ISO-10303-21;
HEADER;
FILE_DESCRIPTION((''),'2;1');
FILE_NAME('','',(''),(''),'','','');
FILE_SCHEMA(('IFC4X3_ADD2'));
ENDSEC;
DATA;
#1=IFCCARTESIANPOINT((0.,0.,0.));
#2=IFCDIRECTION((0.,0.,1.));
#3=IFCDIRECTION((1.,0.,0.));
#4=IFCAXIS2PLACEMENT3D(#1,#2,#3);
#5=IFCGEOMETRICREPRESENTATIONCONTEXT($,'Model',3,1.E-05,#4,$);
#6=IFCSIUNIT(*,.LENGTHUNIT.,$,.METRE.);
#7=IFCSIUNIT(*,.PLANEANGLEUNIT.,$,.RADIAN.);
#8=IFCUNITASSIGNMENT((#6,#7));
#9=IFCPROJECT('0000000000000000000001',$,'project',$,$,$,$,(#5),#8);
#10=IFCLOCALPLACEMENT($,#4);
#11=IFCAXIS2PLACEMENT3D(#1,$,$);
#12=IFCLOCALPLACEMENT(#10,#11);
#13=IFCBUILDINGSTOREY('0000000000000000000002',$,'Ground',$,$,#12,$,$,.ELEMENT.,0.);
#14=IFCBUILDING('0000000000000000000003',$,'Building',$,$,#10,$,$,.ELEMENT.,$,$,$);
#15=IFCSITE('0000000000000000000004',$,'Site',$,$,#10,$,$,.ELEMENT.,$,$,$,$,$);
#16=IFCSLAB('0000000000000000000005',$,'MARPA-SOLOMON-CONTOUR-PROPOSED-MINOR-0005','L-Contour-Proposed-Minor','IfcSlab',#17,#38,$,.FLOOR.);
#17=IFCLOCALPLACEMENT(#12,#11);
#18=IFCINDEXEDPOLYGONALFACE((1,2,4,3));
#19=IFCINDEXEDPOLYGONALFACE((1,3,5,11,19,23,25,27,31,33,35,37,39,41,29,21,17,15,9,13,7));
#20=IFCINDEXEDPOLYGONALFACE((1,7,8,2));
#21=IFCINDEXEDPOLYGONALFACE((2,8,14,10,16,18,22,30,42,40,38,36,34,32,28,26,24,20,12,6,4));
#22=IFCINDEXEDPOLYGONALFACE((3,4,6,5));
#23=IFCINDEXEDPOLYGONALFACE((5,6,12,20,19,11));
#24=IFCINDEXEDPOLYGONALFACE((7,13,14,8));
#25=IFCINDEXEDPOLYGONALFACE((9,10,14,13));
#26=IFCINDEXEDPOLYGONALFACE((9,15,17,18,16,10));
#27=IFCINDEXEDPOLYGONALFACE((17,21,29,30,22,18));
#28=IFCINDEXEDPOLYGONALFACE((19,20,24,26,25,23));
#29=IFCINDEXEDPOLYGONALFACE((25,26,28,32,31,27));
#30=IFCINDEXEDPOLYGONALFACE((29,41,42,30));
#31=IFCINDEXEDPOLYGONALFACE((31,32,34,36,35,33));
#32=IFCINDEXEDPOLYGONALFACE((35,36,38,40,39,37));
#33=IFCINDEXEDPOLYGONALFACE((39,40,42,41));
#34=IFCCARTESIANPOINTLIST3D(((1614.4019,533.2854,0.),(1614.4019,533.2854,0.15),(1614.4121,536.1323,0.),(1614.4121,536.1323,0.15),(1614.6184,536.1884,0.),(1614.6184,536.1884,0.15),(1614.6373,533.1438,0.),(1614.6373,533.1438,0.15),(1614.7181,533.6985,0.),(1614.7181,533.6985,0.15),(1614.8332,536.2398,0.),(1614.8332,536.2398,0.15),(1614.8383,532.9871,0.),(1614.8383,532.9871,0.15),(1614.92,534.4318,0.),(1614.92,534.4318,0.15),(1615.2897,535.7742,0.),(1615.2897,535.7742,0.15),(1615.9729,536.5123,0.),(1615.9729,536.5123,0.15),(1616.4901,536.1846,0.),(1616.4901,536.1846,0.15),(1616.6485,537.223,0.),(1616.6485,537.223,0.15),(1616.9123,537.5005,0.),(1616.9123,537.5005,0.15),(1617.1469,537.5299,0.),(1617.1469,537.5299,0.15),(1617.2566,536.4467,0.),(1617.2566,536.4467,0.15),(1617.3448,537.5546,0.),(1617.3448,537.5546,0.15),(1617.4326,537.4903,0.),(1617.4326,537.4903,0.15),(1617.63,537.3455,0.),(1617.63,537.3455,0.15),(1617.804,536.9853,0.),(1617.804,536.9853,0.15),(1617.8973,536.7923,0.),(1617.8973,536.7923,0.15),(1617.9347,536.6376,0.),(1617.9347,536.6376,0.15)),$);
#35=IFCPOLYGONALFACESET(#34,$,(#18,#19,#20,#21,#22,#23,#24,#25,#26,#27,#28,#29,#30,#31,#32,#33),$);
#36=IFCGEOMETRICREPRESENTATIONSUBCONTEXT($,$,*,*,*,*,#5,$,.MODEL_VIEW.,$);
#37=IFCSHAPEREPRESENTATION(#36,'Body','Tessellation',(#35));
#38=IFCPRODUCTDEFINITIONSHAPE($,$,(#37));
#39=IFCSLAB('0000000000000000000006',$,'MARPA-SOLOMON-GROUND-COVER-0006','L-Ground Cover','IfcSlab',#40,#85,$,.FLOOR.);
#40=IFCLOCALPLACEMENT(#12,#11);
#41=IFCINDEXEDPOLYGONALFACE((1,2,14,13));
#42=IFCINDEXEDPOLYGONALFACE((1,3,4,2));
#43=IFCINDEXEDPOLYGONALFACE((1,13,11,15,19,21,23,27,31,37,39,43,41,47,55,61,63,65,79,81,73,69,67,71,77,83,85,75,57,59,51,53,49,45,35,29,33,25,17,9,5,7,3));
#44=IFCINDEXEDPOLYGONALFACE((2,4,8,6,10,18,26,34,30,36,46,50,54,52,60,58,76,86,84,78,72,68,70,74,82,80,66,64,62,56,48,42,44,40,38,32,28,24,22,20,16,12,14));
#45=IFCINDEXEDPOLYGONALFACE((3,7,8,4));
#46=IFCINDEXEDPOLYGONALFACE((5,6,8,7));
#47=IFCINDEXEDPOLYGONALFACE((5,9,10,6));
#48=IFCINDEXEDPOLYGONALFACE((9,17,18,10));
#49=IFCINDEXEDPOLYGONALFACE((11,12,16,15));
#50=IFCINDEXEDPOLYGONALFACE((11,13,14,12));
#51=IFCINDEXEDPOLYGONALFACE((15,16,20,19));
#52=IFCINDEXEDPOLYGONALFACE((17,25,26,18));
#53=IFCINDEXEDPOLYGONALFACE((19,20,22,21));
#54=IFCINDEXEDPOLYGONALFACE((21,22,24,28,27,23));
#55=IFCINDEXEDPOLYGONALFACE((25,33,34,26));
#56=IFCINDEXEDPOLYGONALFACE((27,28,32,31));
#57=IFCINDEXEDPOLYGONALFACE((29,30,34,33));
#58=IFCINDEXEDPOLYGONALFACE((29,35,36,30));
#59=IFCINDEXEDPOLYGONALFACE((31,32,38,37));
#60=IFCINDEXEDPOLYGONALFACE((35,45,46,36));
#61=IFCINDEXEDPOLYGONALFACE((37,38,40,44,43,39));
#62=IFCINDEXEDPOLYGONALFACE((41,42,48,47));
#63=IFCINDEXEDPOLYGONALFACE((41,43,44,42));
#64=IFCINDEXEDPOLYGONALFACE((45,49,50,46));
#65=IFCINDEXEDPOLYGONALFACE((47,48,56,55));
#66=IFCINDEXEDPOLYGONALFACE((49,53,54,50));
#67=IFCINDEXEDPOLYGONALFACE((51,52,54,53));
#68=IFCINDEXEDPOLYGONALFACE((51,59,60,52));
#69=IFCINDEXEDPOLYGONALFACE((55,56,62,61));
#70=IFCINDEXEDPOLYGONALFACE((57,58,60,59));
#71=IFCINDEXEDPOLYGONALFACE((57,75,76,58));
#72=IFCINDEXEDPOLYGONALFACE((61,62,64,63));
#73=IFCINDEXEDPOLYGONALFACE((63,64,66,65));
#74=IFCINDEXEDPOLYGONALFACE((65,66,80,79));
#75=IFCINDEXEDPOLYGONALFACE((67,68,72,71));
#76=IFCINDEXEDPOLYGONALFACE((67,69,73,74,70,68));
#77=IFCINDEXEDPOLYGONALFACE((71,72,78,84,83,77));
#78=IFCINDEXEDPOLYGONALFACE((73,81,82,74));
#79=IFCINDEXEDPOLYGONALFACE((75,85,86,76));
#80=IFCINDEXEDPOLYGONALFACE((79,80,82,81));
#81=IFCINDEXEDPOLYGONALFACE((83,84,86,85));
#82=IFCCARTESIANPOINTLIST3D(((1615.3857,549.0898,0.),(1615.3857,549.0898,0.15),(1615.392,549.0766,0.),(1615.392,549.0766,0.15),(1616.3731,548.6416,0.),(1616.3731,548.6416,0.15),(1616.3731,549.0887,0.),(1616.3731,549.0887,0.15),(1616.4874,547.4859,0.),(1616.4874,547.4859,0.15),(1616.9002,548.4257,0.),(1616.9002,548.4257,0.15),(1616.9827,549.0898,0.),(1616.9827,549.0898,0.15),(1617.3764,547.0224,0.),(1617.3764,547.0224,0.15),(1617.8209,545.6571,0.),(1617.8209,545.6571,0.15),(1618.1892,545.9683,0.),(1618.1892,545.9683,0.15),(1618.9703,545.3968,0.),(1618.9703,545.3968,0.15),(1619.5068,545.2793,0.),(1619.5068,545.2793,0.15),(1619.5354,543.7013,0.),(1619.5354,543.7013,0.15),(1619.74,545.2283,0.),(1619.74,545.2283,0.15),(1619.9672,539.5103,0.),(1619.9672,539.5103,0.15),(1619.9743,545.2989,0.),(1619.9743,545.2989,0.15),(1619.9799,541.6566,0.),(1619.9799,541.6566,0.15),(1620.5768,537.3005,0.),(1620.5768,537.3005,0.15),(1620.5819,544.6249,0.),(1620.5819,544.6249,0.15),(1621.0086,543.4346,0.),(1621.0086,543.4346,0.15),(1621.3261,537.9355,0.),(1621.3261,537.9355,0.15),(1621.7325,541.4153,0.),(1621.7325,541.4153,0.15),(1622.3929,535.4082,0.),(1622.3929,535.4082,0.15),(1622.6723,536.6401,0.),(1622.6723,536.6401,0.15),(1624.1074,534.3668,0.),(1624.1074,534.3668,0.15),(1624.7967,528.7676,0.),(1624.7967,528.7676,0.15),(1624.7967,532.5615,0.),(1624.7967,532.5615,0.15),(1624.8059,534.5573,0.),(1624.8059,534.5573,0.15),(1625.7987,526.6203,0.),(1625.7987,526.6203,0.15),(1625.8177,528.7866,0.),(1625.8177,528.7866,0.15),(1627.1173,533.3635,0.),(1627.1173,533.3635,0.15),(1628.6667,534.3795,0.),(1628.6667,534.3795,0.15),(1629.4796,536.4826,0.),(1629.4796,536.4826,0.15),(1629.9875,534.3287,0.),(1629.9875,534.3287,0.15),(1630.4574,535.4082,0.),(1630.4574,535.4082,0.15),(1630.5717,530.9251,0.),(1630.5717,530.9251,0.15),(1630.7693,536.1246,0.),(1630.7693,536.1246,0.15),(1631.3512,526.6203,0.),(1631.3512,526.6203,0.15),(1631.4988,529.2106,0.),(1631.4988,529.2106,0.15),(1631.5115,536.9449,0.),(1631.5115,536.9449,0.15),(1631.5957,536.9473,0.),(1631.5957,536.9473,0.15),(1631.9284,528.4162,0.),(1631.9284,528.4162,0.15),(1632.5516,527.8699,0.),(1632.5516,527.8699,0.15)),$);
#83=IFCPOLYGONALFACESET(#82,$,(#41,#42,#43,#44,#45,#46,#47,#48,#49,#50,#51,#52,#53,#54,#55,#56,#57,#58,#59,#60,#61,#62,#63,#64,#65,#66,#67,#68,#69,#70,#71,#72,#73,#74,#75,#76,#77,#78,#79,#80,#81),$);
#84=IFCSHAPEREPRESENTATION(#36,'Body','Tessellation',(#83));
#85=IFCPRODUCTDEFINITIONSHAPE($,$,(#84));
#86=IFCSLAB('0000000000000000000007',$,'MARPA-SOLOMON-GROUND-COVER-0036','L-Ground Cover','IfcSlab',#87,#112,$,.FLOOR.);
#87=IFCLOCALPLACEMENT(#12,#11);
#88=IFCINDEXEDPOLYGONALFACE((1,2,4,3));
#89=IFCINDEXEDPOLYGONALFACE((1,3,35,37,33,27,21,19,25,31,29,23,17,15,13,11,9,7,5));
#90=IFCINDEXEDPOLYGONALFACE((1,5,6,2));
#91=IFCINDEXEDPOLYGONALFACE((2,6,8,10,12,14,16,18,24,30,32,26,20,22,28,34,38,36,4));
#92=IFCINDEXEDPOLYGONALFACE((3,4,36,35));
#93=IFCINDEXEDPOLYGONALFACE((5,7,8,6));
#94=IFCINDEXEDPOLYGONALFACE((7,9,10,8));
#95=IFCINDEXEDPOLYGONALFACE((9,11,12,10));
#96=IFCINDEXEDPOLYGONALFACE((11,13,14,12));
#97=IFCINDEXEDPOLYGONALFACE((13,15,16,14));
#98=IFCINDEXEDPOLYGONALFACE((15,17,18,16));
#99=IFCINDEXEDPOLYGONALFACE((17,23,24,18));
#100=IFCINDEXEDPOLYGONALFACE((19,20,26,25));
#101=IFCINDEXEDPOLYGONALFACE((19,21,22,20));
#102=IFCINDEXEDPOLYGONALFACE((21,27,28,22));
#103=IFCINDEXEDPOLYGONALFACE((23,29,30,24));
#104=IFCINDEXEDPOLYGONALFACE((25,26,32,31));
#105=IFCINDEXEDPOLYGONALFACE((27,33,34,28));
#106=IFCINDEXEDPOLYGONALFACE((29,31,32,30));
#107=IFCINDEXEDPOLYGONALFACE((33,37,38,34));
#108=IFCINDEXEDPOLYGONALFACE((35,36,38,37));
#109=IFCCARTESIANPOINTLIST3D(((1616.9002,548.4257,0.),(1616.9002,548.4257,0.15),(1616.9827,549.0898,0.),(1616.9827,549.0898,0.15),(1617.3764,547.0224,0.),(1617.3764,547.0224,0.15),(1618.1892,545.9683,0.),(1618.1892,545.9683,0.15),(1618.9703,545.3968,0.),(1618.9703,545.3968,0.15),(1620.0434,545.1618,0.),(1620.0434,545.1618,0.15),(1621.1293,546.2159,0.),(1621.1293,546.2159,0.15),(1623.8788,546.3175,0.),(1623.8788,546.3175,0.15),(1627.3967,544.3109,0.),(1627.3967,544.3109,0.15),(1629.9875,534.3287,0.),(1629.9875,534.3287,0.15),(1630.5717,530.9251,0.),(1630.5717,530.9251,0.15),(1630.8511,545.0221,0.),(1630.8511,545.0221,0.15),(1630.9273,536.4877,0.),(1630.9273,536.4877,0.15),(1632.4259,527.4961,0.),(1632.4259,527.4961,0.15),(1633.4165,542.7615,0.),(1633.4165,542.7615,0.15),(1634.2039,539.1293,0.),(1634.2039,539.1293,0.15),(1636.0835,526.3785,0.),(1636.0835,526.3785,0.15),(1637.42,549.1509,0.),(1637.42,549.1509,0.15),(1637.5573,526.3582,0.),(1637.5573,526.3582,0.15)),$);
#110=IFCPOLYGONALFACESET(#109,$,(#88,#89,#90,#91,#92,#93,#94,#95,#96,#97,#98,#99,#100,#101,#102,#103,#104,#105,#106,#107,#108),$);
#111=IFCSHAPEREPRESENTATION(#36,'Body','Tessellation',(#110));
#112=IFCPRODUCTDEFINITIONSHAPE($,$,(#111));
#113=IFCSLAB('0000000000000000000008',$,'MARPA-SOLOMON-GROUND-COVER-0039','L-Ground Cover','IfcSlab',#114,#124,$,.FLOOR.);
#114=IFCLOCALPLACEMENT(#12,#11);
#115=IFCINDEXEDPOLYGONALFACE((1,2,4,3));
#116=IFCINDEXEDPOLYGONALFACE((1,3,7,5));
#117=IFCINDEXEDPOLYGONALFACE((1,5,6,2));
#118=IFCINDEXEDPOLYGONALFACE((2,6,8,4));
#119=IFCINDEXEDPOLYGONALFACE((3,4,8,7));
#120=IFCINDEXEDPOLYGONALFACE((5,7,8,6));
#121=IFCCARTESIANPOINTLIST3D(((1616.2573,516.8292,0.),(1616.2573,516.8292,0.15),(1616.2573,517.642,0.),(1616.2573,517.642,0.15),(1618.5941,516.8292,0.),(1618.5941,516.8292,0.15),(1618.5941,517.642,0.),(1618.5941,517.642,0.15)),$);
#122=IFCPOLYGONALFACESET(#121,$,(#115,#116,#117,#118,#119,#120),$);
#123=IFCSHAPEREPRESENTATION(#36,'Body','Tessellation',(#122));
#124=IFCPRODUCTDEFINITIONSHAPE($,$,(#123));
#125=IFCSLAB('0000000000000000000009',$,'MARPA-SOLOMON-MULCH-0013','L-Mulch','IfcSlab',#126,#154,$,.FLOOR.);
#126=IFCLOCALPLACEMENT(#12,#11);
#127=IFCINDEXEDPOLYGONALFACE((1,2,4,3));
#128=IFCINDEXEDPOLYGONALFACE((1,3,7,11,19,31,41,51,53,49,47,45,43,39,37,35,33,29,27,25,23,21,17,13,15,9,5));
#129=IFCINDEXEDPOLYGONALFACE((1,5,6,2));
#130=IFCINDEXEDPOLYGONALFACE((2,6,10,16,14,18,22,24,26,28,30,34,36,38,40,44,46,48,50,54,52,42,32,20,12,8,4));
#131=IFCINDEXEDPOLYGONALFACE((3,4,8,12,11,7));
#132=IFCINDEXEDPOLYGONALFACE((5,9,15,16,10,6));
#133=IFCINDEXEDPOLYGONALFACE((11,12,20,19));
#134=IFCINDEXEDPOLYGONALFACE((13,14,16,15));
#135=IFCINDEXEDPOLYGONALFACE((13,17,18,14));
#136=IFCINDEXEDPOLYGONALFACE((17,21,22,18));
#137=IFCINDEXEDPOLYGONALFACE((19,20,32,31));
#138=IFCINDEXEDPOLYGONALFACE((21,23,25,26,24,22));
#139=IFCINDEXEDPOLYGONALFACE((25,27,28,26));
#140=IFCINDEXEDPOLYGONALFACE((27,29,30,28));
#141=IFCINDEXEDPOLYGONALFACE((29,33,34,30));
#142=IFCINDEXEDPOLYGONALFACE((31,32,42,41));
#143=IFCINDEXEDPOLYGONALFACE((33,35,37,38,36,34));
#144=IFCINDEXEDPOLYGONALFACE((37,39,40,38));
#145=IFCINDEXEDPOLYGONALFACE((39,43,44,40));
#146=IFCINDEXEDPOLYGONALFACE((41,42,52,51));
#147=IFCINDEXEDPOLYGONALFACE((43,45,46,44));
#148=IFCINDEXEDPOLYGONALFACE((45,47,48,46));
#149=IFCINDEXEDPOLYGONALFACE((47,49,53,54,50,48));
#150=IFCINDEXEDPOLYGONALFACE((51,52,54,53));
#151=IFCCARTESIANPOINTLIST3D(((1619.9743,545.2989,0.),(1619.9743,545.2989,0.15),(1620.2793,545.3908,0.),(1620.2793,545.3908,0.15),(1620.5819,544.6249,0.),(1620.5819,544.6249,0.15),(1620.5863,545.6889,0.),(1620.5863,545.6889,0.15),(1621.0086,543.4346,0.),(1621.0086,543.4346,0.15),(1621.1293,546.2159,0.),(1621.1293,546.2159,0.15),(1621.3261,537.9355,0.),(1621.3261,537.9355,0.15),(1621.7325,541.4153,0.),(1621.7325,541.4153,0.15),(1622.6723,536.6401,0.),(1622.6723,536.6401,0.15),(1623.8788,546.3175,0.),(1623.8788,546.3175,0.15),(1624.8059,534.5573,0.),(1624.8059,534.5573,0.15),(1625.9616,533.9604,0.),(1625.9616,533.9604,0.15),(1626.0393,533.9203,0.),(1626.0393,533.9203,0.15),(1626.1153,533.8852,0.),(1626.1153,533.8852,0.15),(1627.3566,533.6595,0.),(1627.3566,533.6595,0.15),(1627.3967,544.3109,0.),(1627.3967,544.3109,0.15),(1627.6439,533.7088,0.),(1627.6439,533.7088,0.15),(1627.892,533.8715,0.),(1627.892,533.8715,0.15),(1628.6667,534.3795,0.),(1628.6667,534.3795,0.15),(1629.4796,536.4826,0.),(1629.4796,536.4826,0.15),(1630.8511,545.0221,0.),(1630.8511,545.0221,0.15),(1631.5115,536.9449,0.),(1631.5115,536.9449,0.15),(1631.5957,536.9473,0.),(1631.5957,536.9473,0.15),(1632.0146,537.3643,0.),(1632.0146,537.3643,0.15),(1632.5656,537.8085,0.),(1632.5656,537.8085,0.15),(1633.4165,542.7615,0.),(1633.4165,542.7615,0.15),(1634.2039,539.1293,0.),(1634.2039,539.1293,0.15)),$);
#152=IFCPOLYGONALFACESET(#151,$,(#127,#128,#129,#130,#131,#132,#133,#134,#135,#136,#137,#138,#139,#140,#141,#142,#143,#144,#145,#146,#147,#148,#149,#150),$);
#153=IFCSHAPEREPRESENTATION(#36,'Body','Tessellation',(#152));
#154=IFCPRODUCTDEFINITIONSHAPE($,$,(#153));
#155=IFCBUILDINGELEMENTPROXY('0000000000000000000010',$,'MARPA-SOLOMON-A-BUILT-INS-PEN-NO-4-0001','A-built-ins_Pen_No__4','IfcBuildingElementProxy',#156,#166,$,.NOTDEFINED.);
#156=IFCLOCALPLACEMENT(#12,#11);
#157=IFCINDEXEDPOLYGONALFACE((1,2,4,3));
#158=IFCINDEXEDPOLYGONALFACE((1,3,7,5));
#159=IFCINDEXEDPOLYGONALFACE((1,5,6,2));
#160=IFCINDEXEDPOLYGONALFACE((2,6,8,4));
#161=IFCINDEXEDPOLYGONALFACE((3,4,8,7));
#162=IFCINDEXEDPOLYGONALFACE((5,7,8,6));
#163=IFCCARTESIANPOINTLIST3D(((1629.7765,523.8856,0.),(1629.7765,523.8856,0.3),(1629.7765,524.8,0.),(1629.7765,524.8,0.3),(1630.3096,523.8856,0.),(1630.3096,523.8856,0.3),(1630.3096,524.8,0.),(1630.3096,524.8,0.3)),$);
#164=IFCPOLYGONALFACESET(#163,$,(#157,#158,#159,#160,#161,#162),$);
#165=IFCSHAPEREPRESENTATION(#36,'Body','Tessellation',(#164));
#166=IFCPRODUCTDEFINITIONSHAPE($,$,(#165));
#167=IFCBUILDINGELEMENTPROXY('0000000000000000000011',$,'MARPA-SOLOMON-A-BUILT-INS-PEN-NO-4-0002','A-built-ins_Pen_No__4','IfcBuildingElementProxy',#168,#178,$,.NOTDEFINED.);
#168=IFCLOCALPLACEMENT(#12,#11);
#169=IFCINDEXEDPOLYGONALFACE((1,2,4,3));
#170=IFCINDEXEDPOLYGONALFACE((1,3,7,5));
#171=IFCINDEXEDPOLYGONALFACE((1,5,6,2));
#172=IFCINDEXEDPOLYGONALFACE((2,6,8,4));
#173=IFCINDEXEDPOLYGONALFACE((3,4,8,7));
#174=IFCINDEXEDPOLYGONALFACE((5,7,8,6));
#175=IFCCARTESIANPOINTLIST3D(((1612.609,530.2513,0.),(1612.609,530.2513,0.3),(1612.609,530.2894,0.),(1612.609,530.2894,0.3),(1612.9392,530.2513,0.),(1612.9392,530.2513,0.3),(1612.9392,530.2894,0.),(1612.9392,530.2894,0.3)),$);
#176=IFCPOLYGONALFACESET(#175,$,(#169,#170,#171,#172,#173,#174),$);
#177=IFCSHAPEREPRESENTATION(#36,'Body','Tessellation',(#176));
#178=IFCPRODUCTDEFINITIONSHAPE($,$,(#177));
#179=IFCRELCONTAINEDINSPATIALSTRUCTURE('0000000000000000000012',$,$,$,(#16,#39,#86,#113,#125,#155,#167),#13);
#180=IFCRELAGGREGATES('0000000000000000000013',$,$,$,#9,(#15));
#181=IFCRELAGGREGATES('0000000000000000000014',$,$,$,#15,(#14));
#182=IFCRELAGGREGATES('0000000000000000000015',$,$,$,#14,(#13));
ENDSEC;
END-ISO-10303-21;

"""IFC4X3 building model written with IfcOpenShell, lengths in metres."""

from ifc_helpers import new_model, si_unit, frame, origin, origin_with_axes, place, context, subcontext, project, spatial, polyline, outline, extrude, element, save


model = new_model("IFC4X3")

# Units and contexts
model_context = context("Model", 3, precision=1e-05, world=origin_with_axes())
sub_context = subcontext(model_context, None, None, "MODEL_VIEW")
ifc_project = project(units=[si_unit("LENGTHUNIT", "METRE"), si_unit("PLANEANGLEUNIT", "RADIAN")], contexts=[model_context])

# Site, building, storey
placement = place(None, origin_with_axes())
site = spatial("IfcSite", under=ifc_project, at=placement, Name="Site", CompositionType="ELEMENT")
building = spatial("IfcBuilding", under=site, at=placement, Name="Building", CompositionType="ELEMENT")
storey_placement = place(placement, origin())
storey = spatial("IfcBuildingStorey", under=building, at=storey_placement, Name="Ground", CompositionType="ELEMENT", Elevation=0.0)

# Slabs
slab_1_placement = place(storey_placement, frame((1614.4019, 532.9871, 0.0)))
element("IfcSlab", 1, at=slab_1_placement, inside=storey, Name="MARPA-SOLOMON-CONTOUR-PROPOSED-MINOR-0005", Description="L-Contour-Proposed-Minor", ObjectType="IfcSlab", PredefinedType="FLOOR", context=sub_context, shape_type="SweptSolid", body=[
    extrude(outline(polyline([(0.0102, 3.1452), (0.2165, 3.2013), (0.4313, 3.2527), (1.571, 3.5252), (2.2466, 4.2359), (2.5104, 4.5134), (2.745, 4.5428), (2.943, 4.5675), (3.0307, 4.5032), (3.2281, 4.3584), (3.4021, 3.9982), (3.4954, 3.8052), (3.5329, 3.6505), (2.8547, 3.4596), (2.0882, 3.1975), (0.8878, 2.7871), (0.5181, 1.4447), (0.3162, 0.7114), (0.4364, 0.0), (0.2354, 0.1568), (0.0, 0.2983), (0.0102, 3.1452)])), origin(), (0.0, 0.0, 1.0), 0.15),
])
slab_2_placement = place(storey_placement, frame((1615.3857, 526.6203, 0.0)))
element("IfcSlab", 2, at=slab_2_placement, inside=storey, Name="MARPA-SOLOMON-GROUND-COVER-0006", Description="L-Ground Cover", ObjectType="IfcSlab", PredefinedType="FLOOR", context=sub_context, shape_type="SweptSolid", body=[
    extrude(outline(polyline([(0.0063, 22.4563), (0.9874, 22.4684), (0.9874, 22.0213), (1.1017, 20.8656), (2.4352, 19.0368), (4.1497, 17.081), (4.5942, 15.0363), (4.5815, 12.89), (5.1911, 10.6802), (7.0072, 8.7879), (8.7217, 7.7465), (9.4111, 5.9411), (9.4111, 2.1472), (10.432, 2.1663), (10.413, 0.0), (15.9656, 0.0), (17.1659, 1.2496), (16.5427, 1.7959), (16.1131, 2.5903), (15.186, 4.3048), (14.6018, 7.7084), (15.0717, 8.7879), (15.3836, 9.5043), (16.21, 10.327), (16.1258, 10.3246), (14.0939, 9.8623), (13.281, 7.7592), (11.7316, 6.7432), (9.4202, 7.937), (7.2866, 10.0198), (5.9404, 11.3152), (6.3468, 14.795), (5.6229, 16.8143), (5.1962, 18.0046), (4.5886, 18.6786), (4.3543, 18.6079), (4.1211, 18.659), (3.5846, 18.7765), (2.8035, 19.348), (1.9907, 20.4021), (1.5145, 21.8054), (1.597, 22.4694), (0.0, 22.4694), (0.0063, 22.4563)])), origin(), (0.0, 0.0, 1.0), 0.15),
])
slab_3_placement = place(storey_placement, frame((1616.9002, 526.3582, 0.0)))
element("IfcSlab", 3, at=slab_3_placement, inside=storey, Name="MARPA-SOLOMON-GROUND-COVER-0036", Description="L-Ground Cover", ObjectType="IfcSlab", PredefinedType="FLOOR", context=sub_context, shape_type="SweptSolid", body=[
    extrude(outline(polyline([(0.0825, 22.7316), (0.0, 22.0676), (0.4762, 20.6642), (1.2891, 19.6101), (2.0701, 19.0386), (3.1432, 18.8037), (4.2291, 19.8578), (6.9786, 19.9594), (10.4966, 17.9528), (13.951, 18.664), (16.5164, 16.4034), (17.3038, 12.7712), (14.0272, 10.1296), (13.0874, 7.9706), (13.6716, 4.567), (15.5258, 1.138), (19.1834, 0.0204), (20.6572, 0.0), (20.5198, 22.7927), (0.0825, 22.7316)])), origin(), (0.0, 0.0, 1.0), 0.15),
])
slab_4_placement = place(storey_placement, frame((1616.2573, 516.8292, 0.0)))
element("IfcSlab", 4, at=slab_4_placement, inside=storey, Name="MARPA-SOLOMON-GROUND-COVER-0039", Description="L-Ground Cover", ObjectType="IfcSlab", PredefinedType="FLOOR", context=sub_context, shape_type="SweptSolid", body=[
    extrude(outline(polyline([(0.0, 0.8128), (2.3368, 0.8128), (2.3368, 0.0), (0.0, 0.0), (0.0, 0.8128)])), origin(), (0.0, 0.0, 1.0), 0.15),
])
slab_5_placement = place(storey_placement, frame((1619.9743, 533.6595, 0.0)))
element("IfcSlab", 5, at=slab_5_placement, inside=storey, Name="MARPA-SOLOMON-MULCH-0013", Description="L-Mulch", ObjectType="IfcSlab", PredefinedType="FLOOR", context=sub_context, shape_type="SweptSolid", body=[
    extrude(outline(polyline([(11.6214, 3.2879), (12.0403, 3.7048), (12.5913, 4.1491), (14.2296, 5.4699), (13.4422, 9.1021), (10.8768, 11.3627), (7.4224, 10.6515), (3.9045, 12.6581), (1.155, 12.5565), (0.612, 12.0294), (0.305, 11.7314), (0.0, 11.6394), (0.6076, 10.9654), (1.0343, 9.7752), (1.7582, 7.7559), (1.3518, 4.2761), (2.698, 2.9807), (4.8316, 0.8979), (5.9873, 0.301), (6.065, 0.2608), (6.141, 0.2257), (7.3823, 0.0), (7.6696, 0.0494), (7.9177, 0.2121), (8.6924, 0.7201), (9.5053, 2.8232), (11.5372, 3.2855), (11.6214, 3.2879)])), origin(), (0.0, 0.0, 1.0), 0.15),
])

# Building element proxies
proxy_1_placement = place(placement, frame((1629.7765, 523.8856, 0.0)))
element("IfcBuildingElementProxy", 6, at=proxy_1_placement, inside=storey, Name="MARPA-SOLOMON-A-BUILT-INS-PEN-NO-4-0001", Description="A-built-ins_Pen_No__4", ObjectType="IfcBuildingElementProxy", PredefinedType="NOTDEFINED", context=sub_context, shape_type="SweptSolid", body=[
    extrude(outline(polyline([(0.0, 0.9144), (0.0, 0.0), (0.5331, 0.0), (0.5331, 0.9144), (0.0, 0.9144)])), origin(), (0.0, 0.0, 1.0), 0.3),
])
proxy_2_placement = place(placement, frame((1612.609, 530.2513, 0.0)))
element("IfcBuildingElementProxy", 7, at=proxy_2_placement, inside=storey, Name="MARPA-SOLOMON-A-BUILT-INS-PEN-NO-4-0002", Description="A-built-ins_Pen_No__4", ObjectType="IfcBuildingElementProxy", PredefinedType="NOTDEFINED", context=sub_context, shape_type="SweptSolid", body=[
    extrude(outline(polyline([(0.3302, 0.0381), (0.3302, 0.0), (0.0, 0.0), (0.0, 0.0381), (0.3302, 0.0381)])), origin(), (0.0, 0.0, 1.0), 0.3),
])

save(model, "model.ifc")
